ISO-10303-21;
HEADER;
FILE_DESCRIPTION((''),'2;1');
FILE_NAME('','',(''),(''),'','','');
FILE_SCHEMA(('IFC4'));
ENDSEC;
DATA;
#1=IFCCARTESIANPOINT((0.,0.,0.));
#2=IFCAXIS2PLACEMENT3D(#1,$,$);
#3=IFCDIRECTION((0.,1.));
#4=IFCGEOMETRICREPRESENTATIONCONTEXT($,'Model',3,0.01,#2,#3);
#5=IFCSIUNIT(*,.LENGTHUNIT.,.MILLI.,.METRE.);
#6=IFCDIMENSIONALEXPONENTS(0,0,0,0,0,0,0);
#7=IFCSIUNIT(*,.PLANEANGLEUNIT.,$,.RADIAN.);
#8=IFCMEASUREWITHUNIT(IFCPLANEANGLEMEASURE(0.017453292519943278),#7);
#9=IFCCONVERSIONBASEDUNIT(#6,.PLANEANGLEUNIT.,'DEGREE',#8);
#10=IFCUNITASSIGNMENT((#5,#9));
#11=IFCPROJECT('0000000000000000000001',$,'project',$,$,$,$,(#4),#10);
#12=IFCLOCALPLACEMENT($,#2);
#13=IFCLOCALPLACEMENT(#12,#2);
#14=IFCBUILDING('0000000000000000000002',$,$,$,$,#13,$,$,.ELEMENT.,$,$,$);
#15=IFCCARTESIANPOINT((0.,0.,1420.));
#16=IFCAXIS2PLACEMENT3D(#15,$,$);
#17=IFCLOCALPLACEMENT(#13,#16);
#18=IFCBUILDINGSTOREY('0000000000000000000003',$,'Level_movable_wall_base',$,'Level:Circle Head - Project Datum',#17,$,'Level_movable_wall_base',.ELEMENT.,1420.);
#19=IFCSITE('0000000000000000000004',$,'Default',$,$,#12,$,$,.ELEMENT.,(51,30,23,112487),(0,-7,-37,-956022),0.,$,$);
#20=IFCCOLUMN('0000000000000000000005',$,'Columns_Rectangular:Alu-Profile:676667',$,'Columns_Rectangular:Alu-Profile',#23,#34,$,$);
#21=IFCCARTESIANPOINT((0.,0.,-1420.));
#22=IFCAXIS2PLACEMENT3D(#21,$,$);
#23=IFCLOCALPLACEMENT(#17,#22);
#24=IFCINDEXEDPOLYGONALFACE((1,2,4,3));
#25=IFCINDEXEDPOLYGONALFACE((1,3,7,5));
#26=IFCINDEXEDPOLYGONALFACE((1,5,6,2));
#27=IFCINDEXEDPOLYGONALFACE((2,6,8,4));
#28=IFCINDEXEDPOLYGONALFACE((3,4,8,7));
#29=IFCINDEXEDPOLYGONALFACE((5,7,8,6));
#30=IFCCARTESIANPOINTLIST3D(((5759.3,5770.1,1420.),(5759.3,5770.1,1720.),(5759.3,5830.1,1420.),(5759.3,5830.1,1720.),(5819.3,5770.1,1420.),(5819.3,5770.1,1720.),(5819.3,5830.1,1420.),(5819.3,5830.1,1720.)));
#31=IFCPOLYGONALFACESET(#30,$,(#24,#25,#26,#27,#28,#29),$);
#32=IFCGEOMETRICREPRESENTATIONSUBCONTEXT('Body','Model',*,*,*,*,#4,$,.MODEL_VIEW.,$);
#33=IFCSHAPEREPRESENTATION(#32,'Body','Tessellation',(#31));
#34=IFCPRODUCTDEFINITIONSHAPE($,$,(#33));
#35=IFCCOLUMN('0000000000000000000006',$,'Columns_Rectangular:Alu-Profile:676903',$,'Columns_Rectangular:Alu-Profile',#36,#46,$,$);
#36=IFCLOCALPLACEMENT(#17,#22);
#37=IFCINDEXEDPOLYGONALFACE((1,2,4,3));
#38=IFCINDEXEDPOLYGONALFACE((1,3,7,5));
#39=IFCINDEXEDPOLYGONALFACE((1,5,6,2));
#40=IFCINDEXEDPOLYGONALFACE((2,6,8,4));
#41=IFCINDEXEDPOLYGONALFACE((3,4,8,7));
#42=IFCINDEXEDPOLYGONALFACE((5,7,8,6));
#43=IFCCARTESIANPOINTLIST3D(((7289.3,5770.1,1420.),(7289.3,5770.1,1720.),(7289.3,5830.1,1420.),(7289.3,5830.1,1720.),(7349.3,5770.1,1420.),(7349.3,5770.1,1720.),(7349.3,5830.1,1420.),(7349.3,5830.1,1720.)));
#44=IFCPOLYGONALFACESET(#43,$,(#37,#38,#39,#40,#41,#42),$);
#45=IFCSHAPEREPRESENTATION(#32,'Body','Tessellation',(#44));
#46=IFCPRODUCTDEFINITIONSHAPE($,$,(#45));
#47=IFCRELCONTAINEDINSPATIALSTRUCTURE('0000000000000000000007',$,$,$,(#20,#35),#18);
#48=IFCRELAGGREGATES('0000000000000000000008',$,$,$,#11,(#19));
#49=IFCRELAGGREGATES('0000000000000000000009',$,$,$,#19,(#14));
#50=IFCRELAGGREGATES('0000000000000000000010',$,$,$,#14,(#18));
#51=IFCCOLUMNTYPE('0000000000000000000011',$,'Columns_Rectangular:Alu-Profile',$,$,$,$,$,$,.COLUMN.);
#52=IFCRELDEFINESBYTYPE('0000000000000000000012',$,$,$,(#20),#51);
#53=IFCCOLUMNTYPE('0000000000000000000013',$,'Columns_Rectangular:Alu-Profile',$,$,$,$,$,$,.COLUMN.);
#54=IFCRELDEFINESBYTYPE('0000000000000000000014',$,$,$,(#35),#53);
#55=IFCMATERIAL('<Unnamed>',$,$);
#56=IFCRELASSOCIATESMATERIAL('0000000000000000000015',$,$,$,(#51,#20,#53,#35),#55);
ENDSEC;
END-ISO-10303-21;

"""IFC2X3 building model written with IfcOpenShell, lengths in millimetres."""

from ifc_helpers import new_model, entity, si_unit, converted_unit, direction, frame, frame_2d, origin, place, context, subcontext, project, spatial, rectangle, extrude, source, transform, mapped, material, type_object, type_shapes, element, save


model = new_model("IFC2X3")

# Units and contexts
model_context = context("Model", 3, precision=0.01, world=origin(), true_north=direction((0.0, 1.0)))
body_context = subcontext(model_context, "Body", "Model", "MODEL_VIEW")
ifc_project = project(units=[si_unit("LENGTHUNIT", "METRE", prefix="MILLI"), converted_unit("PLANEANGLEUNIT", "DEGREE", entity("IfcPlaneAngleMeasure", 0.017453292519943278), si_unit("PLANEANGLEUNIT", "RADIAN"), dimensions=[0, 0, 0, 0, 0, 0, 0])], contexts=[model_context])

# Site, building, storey
site_placement = place(None, origin())
site = spatial("IfcSite", under=ifc_project, at=site_placement, Name="Default", CompositionType="ELEMENT", RefLatitude=(51, 30, 23, 112487), RefLongitude=(0, -7, -37, -956022), RefElevation=0.0)
building_placement = place(site_placement, origin())
building = spatial("IfcBuilding", under=site, at=building_placement, CompositionType="ELEMENT")
storey_placement = place(building_placement, frame((0.0, 0.0, 1420.0)))
storey = spatial("IfcBuildingStorey", under=building, at=storey_placement, Name="Level_movable_wall_base", ObjectType="Level:Circle Head - Project Datum", LongName="Level_movable_wall_base", CompositionType="ELEMENT", Elevation=1420.0)

# Columns
ifc_material_1 = material(Name="<Unnamed>")
column_type_1 = type_object("IfcColumnType", Name="Columns_Rectangular:Alu-Profile", PredefinedType="COLUMN", material=ifc_material_1)
shared_shape_1 = source(origin(), body_context, "Body", "SweptSolid", [
    extrude(rectangle(XDim=60.0, YDim=60.0, at=frame_2d((0.0, 0.0), x_axis=(1.0, 0.0))), frame((5789.3, 5800.1, 1420.0), z_axis=(0.0, 0.0, 1.0), x_axis=(-1.0, 0.0, 0.0)), (0.0, 0.0, 1.0), 300.0),
])
type_shapes(column_type_1, [shared_shape_1])
column_1_placement = place(storey_placement, frame((0.0, 0.0, -1420.0)))
element("IfcColumn", 1, at=column_1_placement, inside=storey, type_object=column_type_1, material=ifc_material_1, Name="Columns_Rectangular:Alu-Profile:676667", ObjectType="Columns_Rectangular:Alu-Profile", context=body_context, shape_type="MappedRepresentation", body=[
    mapped(shared_shape_1, transform((0.0, 0.0, 0.0), scale=1.0)),
])
column_type_2 = type_object("IfcColumnType", Name="Columns_Rectangular:Alu-Profile", PredefinedType="COLUMN", material=ifc_material_1)
shared_shape_2 = source(origin(), body_context, "Body", "SweptSolid", [
    extrude(rectangle(XDim=60.0, YDim=60.0, at=frame_2d((0.0, 0.0), x_axis=(1.0, 0.0))), frame((7319.3, 5800.1, 1420.0), z_axis=(0.0, 0.0, 1.0), x_axis=(-1.0, 0.0, 0.0)), (0.0, 0.0, 1.0), 300.0),
])
type_shapes(column_type_2, [shared_shape_2])
column_2_placement = place(storey_placement, frame((0.0, 0.0, -1420.0)))
element("IfcColumn", 2, at=column_2_placement, inside=storey, type_object=column_type_2, material=ifc_material_1, Name="Columns_Rectangular:Alu-Profile:676903", ObjectType="Columns_Rectangular:Alu-Profile", context=body_context, shape_type="MappedRepresentation", body=[
    mapped(shared_shape_2, transform((0.0, 0.0, 0.0), scale=1.0)),
])

save(model, "model.ifc")
